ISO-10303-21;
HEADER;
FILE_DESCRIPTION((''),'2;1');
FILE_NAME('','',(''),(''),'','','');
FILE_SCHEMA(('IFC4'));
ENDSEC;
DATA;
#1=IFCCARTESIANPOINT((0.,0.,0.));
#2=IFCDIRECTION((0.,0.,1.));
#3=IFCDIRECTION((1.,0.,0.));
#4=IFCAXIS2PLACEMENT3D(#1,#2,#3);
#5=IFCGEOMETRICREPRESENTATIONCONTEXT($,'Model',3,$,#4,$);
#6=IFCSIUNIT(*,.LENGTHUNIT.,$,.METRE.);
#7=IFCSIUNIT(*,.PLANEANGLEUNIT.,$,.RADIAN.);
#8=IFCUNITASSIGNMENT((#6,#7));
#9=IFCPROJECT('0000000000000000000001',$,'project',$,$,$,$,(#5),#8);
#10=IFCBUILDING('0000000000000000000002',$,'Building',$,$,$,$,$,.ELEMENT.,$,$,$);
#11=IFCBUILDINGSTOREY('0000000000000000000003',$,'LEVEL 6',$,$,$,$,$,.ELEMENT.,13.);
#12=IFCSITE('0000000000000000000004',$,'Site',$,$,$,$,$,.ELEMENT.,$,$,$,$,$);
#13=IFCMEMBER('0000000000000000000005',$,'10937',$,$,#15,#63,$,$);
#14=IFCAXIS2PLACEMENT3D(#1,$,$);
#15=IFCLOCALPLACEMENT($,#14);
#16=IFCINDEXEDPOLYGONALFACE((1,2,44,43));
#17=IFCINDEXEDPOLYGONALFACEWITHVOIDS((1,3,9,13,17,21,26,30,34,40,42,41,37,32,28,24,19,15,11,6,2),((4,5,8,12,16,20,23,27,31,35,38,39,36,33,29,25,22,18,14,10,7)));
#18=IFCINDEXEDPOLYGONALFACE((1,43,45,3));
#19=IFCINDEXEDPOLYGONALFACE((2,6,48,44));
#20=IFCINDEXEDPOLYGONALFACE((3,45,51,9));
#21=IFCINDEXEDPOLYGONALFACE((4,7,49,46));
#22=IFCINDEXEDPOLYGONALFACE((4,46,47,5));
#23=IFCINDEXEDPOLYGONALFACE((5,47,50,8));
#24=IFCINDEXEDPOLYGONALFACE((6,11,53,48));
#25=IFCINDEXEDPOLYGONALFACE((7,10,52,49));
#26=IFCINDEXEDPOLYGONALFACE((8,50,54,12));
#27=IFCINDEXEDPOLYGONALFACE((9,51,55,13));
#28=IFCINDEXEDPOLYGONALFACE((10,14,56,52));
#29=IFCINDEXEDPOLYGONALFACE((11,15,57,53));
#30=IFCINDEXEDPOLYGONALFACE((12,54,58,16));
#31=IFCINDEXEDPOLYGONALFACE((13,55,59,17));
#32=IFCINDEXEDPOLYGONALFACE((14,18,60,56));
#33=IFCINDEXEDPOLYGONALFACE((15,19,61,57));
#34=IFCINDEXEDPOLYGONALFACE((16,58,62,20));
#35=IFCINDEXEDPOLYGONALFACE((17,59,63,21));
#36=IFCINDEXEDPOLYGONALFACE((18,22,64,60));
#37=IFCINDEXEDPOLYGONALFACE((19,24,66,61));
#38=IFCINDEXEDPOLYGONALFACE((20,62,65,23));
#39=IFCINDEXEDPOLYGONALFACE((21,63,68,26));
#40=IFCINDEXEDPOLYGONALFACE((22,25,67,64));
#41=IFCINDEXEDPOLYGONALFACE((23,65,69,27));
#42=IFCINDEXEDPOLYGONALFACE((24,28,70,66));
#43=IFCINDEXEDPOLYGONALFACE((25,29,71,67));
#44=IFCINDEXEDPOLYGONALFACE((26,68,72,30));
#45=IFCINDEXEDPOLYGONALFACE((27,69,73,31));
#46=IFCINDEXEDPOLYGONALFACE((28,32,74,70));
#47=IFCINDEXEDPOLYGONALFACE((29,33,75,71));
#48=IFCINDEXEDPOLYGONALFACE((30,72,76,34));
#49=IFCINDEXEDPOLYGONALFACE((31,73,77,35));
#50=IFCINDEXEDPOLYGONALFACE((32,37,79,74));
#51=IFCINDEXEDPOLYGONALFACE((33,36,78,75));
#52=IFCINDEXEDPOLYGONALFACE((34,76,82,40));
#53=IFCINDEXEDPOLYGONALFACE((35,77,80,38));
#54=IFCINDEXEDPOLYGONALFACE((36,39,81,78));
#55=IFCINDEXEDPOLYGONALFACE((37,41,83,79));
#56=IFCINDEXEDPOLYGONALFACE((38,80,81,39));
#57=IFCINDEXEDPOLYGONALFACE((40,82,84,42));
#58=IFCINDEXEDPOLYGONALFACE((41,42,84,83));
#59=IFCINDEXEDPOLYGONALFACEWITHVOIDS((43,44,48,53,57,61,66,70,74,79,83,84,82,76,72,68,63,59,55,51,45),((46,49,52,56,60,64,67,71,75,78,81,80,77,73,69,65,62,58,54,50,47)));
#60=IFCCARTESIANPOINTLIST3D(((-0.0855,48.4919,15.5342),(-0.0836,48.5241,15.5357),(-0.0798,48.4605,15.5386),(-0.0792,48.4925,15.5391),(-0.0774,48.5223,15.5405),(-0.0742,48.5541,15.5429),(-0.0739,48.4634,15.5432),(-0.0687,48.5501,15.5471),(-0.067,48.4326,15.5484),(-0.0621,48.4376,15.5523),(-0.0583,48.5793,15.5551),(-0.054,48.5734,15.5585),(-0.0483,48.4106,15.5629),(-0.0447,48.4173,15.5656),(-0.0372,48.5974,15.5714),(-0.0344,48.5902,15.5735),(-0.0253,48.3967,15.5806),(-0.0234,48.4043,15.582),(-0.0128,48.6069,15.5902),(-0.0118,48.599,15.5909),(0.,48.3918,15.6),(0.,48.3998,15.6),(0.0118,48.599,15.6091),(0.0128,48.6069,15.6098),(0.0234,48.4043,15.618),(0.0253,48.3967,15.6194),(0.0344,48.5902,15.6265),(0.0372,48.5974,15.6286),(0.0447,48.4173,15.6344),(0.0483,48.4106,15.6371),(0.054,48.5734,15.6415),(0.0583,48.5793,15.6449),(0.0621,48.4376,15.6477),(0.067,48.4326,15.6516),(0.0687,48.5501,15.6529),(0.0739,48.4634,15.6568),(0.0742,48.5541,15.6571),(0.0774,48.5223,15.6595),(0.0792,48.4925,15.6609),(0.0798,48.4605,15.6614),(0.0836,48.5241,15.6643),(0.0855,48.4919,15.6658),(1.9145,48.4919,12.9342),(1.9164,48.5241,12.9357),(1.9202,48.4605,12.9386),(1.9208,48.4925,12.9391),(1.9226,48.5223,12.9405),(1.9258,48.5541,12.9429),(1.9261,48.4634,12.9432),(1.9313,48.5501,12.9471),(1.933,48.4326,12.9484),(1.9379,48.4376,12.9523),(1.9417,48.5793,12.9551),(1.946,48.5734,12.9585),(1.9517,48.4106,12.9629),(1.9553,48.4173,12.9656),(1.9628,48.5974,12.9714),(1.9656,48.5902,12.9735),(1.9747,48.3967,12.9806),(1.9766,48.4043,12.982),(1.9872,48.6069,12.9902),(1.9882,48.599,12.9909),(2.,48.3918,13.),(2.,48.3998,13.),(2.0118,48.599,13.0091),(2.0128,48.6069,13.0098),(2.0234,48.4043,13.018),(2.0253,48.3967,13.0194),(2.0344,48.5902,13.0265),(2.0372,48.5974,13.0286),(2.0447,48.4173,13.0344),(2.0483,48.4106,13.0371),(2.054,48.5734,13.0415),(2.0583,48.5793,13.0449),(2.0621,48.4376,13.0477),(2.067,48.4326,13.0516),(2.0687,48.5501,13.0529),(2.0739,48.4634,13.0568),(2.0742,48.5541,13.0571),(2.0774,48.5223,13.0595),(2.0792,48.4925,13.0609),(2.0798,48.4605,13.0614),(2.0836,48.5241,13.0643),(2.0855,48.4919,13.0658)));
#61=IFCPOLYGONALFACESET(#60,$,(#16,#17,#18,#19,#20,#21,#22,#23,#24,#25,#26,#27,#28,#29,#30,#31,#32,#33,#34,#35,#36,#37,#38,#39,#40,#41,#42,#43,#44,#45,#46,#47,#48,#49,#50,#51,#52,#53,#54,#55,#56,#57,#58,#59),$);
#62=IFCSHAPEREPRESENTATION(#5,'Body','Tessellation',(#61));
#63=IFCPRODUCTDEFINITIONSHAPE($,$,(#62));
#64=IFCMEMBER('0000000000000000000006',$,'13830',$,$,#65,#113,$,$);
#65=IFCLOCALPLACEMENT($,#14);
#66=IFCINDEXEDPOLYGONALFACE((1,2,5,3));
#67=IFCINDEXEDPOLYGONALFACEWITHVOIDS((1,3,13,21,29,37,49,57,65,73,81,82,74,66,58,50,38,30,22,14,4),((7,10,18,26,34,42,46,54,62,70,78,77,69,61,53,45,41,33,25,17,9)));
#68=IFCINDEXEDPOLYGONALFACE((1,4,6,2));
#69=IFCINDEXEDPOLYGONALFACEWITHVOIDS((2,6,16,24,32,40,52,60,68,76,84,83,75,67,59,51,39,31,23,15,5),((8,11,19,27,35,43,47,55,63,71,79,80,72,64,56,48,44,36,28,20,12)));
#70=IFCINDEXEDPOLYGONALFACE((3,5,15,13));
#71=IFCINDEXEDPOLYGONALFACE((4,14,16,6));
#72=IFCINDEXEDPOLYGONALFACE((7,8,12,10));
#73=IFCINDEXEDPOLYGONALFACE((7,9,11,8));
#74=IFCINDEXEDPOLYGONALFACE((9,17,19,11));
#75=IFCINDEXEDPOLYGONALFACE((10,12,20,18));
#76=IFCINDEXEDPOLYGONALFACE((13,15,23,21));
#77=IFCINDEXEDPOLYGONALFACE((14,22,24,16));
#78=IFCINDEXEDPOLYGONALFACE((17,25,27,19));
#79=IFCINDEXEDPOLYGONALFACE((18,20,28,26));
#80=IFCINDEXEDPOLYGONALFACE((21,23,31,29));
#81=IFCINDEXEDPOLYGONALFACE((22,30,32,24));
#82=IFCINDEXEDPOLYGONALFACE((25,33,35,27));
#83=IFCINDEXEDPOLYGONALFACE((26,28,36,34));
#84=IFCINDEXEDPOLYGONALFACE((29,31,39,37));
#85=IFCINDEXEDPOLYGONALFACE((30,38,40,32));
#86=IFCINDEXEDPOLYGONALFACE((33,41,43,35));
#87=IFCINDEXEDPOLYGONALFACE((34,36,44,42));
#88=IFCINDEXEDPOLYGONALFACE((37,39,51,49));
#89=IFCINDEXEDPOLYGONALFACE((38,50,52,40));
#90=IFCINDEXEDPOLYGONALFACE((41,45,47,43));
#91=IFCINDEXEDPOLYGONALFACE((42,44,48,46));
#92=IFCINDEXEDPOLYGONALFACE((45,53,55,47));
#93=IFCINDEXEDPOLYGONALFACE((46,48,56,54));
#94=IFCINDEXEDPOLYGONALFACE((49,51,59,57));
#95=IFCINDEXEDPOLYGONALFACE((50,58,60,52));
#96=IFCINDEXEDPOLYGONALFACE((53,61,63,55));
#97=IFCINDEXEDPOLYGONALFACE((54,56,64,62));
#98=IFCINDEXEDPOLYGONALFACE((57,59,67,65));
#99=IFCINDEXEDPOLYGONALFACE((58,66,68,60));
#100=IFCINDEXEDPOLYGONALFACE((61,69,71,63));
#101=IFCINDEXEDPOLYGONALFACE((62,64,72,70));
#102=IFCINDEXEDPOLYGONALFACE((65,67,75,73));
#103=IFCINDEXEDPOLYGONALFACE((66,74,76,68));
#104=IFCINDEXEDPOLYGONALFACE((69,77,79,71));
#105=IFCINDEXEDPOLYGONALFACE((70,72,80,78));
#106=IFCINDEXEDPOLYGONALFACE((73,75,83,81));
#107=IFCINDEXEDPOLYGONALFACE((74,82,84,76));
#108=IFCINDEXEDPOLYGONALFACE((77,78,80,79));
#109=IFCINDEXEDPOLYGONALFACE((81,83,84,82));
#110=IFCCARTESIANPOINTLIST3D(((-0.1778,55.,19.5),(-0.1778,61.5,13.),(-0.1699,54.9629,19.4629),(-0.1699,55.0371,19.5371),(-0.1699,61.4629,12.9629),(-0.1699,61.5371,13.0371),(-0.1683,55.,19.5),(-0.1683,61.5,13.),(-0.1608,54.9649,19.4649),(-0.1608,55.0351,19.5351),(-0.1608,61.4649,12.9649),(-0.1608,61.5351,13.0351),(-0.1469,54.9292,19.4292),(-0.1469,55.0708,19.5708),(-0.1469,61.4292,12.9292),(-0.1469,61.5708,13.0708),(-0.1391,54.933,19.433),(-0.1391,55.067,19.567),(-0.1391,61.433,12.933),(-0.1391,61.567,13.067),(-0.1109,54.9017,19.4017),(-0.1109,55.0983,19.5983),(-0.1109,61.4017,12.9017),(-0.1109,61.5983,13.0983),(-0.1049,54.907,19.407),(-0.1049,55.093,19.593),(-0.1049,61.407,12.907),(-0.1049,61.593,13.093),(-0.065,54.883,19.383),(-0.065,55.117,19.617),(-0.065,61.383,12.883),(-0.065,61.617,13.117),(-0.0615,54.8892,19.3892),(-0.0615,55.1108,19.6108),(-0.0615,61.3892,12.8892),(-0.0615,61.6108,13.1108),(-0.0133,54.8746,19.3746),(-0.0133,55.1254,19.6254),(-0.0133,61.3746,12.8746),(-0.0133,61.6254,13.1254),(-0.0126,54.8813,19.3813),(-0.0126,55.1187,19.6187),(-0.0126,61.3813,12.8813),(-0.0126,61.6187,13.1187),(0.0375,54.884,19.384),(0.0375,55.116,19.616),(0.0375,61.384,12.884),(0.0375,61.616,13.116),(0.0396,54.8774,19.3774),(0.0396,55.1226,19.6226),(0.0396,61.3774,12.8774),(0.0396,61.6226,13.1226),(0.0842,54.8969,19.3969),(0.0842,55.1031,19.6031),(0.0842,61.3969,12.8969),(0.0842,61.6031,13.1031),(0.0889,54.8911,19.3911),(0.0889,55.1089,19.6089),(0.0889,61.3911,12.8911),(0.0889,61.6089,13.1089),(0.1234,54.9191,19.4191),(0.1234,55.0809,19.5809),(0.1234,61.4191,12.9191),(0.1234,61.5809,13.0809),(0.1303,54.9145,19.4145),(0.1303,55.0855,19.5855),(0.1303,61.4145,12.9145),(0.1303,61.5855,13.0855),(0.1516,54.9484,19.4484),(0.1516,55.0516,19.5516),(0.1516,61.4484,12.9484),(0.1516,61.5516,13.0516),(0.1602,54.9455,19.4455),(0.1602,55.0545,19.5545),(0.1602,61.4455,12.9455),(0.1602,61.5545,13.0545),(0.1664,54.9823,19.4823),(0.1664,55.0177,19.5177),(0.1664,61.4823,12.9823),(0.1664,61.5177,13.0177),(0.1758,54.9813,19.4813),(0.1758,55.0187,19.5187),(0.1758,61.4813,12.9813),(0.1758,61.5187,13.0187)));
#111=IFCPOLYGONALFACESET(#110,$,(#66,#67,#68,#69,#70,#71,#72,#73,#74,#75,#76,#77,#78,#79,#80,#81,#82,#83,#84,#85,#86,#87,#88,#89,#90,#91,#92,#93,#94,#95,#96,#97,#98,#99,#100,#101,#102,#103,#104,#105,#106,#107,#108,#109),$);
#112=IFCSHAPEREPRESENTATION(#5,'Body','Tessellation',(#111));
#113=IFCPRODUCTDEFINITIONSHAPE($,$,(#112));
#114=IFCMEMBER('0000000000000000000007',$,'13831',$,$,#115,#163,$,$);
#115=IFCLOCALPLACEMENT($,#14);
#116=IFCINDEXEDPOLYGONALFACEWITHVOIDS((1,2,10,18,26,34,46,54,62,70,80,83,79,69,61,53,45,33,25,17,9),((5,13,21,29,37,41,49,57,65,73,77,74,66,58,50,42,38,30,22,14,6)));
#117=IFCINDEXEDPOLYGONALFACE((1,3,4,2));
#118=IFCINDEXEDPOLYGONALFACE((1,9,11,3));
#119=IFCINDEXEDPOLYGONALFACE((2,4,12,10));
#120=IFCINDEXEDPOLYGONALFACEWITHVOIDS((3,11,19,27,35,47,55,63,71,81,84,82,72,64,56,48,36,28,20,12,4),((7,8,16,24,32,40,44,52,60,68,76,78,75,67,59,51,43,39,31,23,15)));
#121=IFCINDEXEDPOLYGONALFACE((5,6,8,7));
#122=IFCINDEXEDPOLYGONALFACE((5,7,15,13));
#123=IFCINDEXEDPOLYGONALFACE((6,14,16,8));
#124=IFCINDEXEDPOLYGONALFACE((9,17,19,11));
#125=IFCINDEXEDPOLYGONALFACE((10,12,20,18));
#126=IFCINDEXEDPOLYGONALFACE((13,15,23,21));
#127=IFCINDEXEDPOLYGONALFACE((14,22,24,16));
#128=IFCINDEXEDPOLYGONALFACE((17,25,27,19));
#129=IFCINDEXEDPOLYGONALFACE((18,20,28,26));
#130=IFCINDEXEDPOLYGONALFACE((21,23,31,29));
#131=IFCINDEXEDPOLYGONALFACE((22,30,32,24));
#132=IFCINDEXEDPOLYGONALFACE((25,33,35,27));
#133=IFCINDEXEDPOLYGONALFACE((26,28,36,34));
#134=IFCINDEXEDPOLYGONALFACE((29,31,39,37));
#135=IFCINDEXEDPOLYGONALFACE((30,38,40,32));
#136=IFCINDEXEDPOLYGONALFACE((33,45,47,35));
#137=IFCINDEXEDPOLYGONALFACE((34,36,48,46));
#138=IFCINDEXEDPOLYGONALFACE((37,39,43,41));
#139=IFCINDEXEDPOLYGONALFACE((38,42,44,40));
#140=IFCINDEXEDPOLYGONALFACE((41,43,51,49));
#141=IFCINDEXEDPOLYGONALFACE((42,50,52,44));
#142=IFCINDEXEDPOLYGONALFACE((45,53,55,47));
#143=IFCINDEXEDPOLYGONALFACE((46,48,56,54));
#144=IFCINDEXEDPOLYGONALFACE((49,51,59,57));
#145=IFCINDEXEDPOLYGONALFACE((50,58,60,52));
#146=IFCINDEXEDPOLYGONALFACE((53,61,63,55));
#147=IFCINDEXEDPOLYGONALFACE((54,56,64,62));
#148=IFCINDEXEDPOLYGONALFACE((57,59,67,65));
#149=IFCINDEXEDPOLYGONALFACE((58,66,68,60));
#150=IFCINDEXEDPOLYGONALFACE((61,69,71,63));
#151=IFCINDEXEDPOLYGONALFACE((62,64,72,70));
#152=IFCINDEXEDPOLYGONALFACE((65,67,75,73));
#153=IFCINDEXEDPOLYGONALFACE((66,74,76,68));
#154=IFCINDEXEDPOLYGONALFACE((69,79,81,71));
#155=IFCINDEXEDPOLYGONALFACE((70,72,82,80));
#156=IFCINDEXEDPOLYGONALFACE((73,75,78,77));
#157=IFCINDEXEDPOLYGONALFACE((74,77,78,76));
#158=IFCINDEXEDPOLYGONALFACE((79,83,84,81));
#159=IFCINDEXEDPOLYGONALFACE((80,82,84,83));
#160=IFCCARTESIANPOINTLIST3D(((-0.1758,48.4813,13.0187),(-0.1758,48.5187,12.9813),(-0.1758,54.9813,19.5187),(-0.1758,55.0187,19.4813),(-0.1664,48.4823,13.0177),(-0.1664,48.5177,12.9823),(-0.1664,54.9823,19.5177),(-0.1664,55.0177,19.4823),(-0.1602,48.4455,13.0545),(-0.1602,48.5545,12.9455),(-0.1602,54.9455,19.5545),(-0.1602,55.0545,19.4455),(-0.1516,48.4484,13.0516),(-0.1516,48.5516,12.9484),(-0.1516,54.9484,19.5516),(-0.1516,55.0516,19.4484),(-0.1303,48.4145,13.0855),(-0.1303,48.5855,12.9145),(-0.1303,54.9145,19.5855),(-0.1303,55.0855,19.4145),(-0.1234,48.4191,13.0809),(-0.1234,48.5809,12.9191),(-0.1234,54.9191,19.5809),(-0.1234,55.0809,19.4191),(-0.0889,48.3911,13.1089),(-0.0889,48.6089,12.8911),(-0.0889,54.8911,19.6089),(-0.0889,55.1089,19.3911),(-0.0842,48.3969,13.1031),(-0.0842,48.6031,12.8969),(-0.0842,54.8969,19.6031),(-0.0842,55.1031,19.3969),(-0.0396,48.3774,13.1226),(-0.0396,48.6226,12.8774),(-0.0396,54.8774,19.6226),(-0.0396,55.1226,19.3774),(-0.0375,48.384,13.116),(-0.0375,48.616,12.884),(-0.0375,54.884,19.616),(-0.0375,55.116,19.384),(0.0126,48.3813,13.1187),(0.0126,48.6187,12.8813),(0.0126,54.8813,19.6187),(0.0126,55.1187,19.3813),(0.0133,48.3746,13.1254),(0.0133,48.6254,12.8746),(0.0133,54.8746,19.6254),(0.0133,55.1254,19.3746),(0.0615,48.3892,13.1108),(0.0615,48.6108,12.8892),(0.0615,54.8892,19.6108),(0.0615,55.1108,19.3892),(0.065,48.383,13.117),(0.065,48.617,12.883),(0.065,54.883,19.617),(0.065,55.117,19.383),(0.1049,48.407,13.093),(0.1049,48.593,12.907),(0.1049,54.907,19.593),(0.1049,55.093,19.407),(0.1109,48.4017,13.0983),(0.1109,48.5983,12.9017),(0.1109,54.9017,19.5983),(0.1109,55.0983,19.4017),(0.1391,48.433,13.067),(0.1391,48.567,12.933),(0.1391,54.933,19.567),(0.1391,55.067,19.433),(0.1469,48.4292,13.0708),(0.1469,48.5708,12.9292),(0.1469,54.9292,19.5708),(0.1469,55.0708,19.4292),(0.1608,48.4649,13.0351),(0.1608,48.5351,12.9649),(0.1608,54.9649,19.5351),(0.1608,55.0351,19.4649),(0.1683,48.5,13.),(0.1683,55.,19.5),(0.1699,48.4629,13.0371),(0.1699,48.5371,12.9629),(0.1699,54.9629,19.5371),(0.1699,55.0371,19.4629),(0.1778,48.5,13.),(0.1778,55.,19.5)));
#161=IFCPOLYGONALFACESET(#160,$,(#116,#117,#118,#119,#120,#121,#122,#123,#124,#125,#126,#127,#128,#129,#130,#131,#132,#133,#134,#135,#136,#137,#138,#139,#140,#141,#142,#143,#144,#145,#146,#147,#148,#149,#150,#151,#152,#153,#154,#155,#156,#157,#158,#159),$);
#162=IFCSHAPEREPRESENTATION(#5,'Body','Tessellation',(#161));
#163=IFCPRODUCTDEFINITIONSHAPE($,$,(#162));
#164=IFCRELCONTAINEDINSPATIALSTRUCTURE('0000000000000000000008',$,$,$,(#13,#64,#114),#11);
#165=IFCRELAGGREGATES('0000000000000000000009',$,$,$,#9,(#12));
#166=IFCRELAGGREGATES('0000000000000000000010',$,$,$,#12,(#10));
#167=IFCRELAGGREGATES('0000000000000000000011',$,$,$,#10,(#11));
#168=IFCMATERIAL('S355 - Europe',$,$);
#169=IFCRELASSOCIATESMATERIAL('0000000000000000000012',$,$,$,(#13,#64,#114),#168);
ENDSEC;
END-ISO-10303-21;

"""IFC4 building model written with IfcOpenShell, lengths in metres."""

from ifc_helpers import new_model, si_unit, frame, origin_with_axes, origin_2d_with_axis, place, context, project, spatial, hollow_circle, extrude, material, material_profile, profile_set, profile_usage, element, save


model = new_model("IFC4")

# Units and contexts
model_context = context("Model", 3, world=origin_with_axes())
ifc_project = project(units=[si_unit("LENGTHUNIT", "METRE"), si_unit("PLANEANGLEUNIT", "RADIAN")], contexts=[model_context])

# Site, building, storey
site = spatial("IfcSite", under=ifc_project, Name="Site", CompositionType="ELEMENT")
building = spatial("IfcBuilding", under=site, Name="Building", CompositionType="ELEMENT")
storey = spatial("IfcBuildingStorey", under=building, Name="LEVEL 6", CompositionType="ELEMENT", Elevation=13.0)

# Shared definitions
ifc_material = material(Name="S355 - Europe")

# Members
ifc_material_profile_1 = material_profile(ifc_material, hollow_circle(Radius=0.1081, WallThickness=0.008, at=origin_2d_with_axis()))
ifc_profile_set_1 = profile_set([ifc_material_profile_1])
ifc_profile_usage_1 = profile_usage(ifc_profile_set_1, cardinal=10)
member_1_placement = place(None, frame((2.0, 48.5, 13.0), z_axis=(-0.609711, 0.0, 0.792624), x_axis=(0.0, -1.0, 0.0)))
element("IfcMember", 1, at=member_1_placement, inside=storey, material=ifc_profile_usage_1, Name="10937", context=model_context, shape_type="SweptSolid", body=[
    extrude(hollow_circle(Radius=0.1081, WallThickness=0.008, at=origin_2d_with_axis()), origin_with_axes(), (0.0, 0.0, 1.0), 3.2802),
])
ifc_material_profile_2 = material_profile(ifc_material, hollow_circle(Radius=0.1778, WallThickness=0.0095, at=origin_2d_with_axis()))
ifc_profile_set_2 = profile_set([ifc_material_profile_2])
ifc_profile_usage_2 = profile_usage(ifc_profile_set_2, cardinal=10)
member_2_placement = place(None, frame((0.0, 55.0, 19.5), z_axis=(0.0, 0.707107, -0.707107), x_axis=(-1.0, 0.0, 0.0)))
element("IfcMember", 2, at=member_2_placement, inside=storey, material=ifc_profile_usage_2, Name="13830", context=model_context, shape_type="SweptSolid", body=[
    extrude(hollow_circle(Radius=0.1778, WallThickness=0.0095, at=origin_2d_with_axis()), origin_with_axes(), (0.0, 0.0, 1.0), 9.1924),
])
ifc_material_profile_3 = material_profile(ifc_material, hollow_circle(Radius=0.1778, WallThickness=0.0095, at=origin_2d_with_axis()))
ifc_profile_set_3 = profile_set([ifc_material_profile_3])
ifc_profile_usage_3 = profile_usage(ifc_profile_set_3, cardinal=10)
member_3_placement = place(None, frame((0.0, 55.0, 19.5), z_axis=(0.0, -0.707107, -0.707107), x_axis=(1.0, 0.0, 0.0)))
element("IfcMember", 3, at=member_3_placement, inside=storey, material=ifc_profile_usage_3, Name="13831", context=model_context, shape_type="SweptSolid", body=[
    extrude(hollow_circle(Radius=0.1778, WallThickness=0.0095, at=origin_2d_with_axis()), origin_with_axes(), (0.0, 0.0, 1.0), 9.1924),
])

save(model, "model.ifc")
